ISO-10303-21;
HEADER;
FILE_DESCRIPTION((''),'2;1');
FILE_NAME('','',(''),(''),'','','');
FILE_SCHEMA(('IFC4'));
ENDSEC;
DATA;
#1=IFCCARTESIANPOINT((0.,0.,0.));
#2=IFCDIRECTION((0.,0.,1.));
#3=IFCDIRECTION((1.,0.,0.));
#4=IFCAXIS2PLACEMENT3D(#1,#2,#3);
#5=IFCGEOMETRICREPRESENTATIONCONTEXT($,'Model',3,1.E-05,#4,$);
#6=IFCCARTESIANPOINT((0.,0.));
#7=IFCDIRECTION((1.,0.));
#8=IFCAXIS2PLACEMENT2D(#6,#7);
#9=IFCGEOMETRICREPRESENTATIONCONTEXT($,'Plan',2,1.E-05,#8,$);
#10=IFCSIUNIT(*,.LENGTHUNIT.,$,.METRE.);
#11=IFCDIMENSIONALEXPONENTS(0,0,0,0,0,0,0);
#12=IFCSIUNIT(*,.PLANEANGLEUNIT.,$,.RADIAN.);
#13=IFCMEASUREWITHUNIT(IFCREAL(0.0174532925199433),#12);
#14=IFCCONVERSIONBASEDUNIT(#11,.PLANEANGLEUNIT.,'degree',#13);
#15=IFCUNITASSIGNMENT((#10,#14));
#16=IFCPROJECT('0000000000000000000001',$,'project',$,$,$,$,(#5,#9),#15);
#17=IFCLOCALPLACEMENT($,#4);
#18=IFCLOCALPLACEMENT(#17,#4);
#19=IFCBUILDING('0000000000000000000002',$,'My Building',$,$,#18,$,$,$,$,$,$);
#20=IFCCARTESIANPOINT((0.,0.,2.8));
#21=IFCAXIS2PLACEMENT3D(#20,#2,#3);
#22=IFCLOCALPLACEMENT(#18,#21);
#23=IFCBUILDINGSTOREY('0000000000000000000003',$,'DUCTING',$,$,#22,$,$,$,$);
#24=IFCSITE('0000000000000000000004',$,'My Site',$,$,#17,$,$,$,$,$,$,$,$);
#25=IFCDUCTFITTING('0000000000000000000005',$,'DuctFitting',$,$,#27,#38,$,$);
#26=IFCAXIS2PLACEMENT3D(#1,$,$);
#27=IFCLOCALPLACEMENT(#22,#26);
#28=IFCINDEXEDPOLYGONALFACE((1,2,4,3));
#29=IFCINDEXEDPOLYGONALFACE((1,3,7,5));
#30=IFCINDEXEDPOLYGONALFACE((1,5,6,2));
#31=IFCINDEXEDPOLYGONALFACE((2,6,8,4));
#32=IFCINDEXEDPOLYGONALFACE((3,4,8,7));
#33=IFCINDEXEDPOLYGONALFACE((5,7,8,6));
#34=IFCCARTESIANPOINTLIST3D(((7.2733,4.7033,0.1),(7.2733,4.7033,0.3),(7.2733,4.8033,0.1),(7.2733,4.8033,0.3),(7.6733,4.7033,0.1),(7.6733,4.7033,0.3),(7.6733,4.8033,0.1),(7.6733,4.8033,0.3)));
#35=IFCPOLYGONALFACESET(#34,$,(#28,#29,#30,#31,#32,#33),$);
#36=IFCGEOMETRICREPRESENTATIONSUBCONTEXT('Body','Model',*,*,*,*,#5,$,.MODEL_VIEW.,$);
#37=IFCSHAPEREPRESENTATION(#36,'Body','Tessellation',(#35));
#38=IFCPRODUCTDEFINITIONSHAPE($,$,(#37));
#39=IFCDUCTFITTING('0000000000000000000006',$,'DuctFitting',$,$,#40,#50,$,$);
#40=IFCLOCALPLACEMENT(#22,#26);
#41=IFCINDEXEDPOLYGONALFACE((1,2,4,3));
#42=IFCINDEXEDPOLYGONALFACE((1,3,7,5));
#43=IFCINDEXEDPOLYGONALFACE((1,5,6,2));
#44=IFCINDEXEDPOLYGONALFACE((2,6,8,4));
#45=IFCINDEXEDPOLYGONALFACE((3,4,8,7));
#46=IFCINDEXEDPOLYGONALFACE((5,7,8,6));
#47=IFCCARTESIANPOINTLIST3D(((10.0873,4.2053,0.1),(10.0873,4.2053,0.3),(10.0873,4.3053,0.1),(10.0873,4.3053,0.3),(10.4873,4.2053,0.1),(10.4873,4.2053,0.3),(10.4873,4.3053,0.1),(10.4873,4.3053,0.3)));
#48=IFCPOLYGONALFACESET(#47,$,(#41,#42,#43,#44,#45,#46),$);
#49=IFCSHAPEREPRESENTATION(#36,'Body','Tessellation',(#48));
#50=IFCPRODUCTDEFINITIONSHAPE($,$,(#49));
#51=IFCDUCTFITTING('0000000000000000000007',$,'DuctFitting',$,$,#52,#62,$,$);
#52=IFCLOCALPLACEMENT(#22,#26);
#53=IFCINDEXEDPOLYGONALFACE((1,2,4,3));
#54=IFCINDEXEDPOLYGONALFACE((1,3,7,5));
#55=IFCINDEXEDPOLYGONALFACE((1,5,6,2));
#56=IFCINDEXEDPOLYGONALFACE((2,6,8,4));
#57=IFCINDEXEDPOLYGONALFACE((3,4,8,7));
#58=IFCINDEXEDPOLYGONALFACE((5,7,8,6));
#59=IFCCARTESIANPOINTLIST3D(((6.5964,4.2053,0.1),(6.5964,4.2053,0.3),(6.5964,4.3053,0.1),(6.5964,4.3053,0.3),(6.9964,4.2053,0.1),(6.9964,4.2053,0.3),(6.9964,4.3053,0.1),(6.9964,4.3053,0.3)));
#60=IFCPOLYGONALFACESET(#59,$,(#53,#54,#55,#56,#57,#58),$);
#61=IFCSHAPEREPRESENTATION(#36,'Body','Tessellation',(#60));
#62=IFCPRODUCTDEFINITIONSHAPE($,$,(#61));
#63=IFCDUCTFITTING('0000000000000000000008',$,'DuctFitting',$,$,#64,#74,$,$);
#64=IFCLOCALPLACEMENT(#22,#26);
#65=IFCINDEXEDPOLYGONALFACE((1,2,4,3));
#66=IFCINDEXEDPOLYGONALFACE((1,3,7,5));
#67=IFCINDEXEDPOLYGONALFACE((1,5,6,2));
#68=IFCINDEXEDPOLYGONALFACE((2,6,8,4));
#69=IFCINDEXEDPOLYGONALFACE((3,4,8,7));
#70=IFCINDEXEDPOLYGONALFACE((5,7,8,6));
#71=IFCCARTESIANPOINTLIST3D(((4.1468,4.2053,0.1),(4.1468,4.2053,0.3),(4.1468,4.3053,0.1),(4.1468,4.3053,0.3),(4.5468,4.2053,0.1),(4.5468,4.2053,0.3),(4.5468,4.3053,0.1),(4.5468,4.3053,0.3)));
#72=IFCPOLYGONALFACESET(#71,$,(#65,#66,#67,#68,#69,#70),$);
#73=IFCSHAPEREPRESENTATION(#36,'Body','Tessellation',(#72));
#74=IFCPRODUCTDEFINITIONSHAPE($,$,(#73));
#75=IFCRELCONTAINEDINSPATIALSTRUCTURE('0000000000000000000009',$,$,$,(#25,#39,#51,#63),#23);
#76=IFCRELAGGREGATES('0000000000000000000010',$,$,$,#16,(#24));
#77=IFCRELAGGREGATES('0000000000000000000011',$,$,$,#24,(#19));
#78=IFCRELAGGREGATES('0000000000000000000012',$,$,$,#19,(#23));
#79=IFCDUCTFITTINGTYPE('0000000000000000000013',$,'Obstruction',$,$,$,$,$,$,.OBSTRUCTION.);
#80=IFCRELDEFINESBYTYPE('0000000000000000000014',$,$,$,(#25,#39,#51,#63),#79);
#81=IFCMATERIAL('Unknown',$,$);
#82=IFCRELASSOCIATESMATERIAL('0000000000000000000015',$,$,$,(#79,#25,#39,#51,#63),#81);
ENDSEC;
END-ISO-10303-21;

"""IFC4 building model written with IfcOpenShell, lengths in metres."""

from ifc_helpers import new_model, entity, si_unit, converted_unit, frame, origin_with_axes, origin_2d_with_axis, place, context, subcontext, project, spatial, rectangle, extrude, material, material_profile, profile_set, profile_usage, type_object, element, save


model = new_model("IFC4")

# Units and contexts
model_context = context("Model", 3, precision=1e-05, world=origin_with_axes())
plan_context = context("Plan", 2, precision=1e-05, world=origin_2d_with_axis())
body_context = subcontext(model_context, "Body", "Model", "MODEL_VIEW")
ifc_project = project(units=[si_unit("LENGTHUNIT", "METRE"), converted_unit("PLANEANGLEUNIT", "degree", entity("IfcReal", 0.0174532925199433), si_unit("PLANEANGLEUNIT", "RADIAN"), dimensions=[0, 0, 0, 0, 0, 0, 0])], contexts=[model_context, plan_context])

# Site, building, storey
site_placement = place(None, origin_with_axes())
site = spatial("IfcSite", under=ifc_project, at=site_placement, Name="My Site")
building_placement = place(site_placement, origin_with_axes())
building = spatial("IfcBuilding", under=site, at=building_placement, Name="My Building")
storey_placement = place(building_placement, frame((0.0, 0.0, 2.8), z_axis=(0.0, 0.0, 1.0), x_axis=(1.0, 0.0, 0.0)))
storey = spatial("IfcBuildingStorey", under=building, at=storey_placement, Name="DUCTING")

# Shared definitions
ifc_material = material(Name="Unknown")

# Duct fittings
ifc_material_profile_1 = material_profile(ifc_material, rectangle(XDim=0.4, YDim=0.2))
ifc_profile_set_1 = profile_set([ifc_material_profile_1])
duct_fitting_type_1 = type_object("IfcDuctFittingType", Name="Obstruction", PredefinedType="OBSTRUCTION", material=ifc_profile_set_1)
ifc_profile_usage_1 = profile_usage(ifc_profile_set_1, cardinal=5)
duct_fitting_1_placement = place(storey_placement, frame((7.4733, 4.7033, 0.2), z_axis=(-0.000031, 1.0, 0.0), x_axis=(-1.0, -0.000031, 0.0)))
element("IfcDuctFitting", 1, at=duct_fitting_1_placement, inside=storey, type_object=duct_fitting_type_1, material=ifc_profile_usage_1, Name="DuctFitting", context=body_context, shape_type="SweptSolid", body=[
    extrude(rectangle(XDim=0.4, YDim=0.2), origin_with_axes(), (0.0, 0.0, 1.0), 0.1),
])
ifc_profile_usage_2 = profile_usage(ifc_profile_set_1, cardinal=5)
duct_fitting_2_placement = place(storey_placement, frame((10.2873, 4.2053, 0.2), z_axis=(-0.000031, 1.0, 0.0), x_axis=(-1.0, -0.000031, 0.0)))
element("IfcDuctFitting", 2, at=duct_fitting_2_placement, inside=storey, type_object=duct_fitting_type_1, material=ifc_profile_usage_2, Name="DuctFitting", context=body_context, shape_type="SweptSolid", body=[
    extrude(rectangle(XDim=0.4, YDim=0.2), origin_with_axes(), (0.0, 0.0, 1.0), 0.1),
])
ifc_profile_usage_3 = profile_usage(ifc_profile_set_1, cardinal=5)
duct_fitting_3_placement = place(storey_placement, frame((6.7964, 4.2053, 0.2), z_axis=(-0.000031, 1.0, 0.0), x_axis=(-1.0, -0.000031, 0.0)))
element("IfcDuctFitting", 3, at=duct_fitting_3_placement, inside=storey, type_object=duct_fitting_type_1, material=ifc_profile_usage_3, Name="DuctFitting", context=body_context, shape_type="SweptSolid", body=[
    extrude(rectangle(XDim=0.4, YDim=0.2), origin_with_axes(), (0.0, 0.0, 1.0), 0.1),
])
ifc_profile_usage_4 = profile_usage(ifc_profile_set_1, cardinal=5)
duct_fitting_4_placement = place(storey_placement, frame((4.3468, 4.2053, 0.2), z_axis=(-0.000031, 1.0, 0.0), x_axis=(-1.0, -0.000031, 0.0)))
element("IfcDuctFitting", 4, at=duct_fitting_4_placement, inside=storey, type_object=duct_fitting_type_1, material=ifc_profile_usage_4, Name="DuctFitting", context=body_context, shape_type="SweptSolid", body=[
    extrude(rectangle(XDim=0.4, YDim=0.2), origin_with_axes(), (0.0, 0.0, 1.0), 0.1),
])

save(model, "model.ifc")
